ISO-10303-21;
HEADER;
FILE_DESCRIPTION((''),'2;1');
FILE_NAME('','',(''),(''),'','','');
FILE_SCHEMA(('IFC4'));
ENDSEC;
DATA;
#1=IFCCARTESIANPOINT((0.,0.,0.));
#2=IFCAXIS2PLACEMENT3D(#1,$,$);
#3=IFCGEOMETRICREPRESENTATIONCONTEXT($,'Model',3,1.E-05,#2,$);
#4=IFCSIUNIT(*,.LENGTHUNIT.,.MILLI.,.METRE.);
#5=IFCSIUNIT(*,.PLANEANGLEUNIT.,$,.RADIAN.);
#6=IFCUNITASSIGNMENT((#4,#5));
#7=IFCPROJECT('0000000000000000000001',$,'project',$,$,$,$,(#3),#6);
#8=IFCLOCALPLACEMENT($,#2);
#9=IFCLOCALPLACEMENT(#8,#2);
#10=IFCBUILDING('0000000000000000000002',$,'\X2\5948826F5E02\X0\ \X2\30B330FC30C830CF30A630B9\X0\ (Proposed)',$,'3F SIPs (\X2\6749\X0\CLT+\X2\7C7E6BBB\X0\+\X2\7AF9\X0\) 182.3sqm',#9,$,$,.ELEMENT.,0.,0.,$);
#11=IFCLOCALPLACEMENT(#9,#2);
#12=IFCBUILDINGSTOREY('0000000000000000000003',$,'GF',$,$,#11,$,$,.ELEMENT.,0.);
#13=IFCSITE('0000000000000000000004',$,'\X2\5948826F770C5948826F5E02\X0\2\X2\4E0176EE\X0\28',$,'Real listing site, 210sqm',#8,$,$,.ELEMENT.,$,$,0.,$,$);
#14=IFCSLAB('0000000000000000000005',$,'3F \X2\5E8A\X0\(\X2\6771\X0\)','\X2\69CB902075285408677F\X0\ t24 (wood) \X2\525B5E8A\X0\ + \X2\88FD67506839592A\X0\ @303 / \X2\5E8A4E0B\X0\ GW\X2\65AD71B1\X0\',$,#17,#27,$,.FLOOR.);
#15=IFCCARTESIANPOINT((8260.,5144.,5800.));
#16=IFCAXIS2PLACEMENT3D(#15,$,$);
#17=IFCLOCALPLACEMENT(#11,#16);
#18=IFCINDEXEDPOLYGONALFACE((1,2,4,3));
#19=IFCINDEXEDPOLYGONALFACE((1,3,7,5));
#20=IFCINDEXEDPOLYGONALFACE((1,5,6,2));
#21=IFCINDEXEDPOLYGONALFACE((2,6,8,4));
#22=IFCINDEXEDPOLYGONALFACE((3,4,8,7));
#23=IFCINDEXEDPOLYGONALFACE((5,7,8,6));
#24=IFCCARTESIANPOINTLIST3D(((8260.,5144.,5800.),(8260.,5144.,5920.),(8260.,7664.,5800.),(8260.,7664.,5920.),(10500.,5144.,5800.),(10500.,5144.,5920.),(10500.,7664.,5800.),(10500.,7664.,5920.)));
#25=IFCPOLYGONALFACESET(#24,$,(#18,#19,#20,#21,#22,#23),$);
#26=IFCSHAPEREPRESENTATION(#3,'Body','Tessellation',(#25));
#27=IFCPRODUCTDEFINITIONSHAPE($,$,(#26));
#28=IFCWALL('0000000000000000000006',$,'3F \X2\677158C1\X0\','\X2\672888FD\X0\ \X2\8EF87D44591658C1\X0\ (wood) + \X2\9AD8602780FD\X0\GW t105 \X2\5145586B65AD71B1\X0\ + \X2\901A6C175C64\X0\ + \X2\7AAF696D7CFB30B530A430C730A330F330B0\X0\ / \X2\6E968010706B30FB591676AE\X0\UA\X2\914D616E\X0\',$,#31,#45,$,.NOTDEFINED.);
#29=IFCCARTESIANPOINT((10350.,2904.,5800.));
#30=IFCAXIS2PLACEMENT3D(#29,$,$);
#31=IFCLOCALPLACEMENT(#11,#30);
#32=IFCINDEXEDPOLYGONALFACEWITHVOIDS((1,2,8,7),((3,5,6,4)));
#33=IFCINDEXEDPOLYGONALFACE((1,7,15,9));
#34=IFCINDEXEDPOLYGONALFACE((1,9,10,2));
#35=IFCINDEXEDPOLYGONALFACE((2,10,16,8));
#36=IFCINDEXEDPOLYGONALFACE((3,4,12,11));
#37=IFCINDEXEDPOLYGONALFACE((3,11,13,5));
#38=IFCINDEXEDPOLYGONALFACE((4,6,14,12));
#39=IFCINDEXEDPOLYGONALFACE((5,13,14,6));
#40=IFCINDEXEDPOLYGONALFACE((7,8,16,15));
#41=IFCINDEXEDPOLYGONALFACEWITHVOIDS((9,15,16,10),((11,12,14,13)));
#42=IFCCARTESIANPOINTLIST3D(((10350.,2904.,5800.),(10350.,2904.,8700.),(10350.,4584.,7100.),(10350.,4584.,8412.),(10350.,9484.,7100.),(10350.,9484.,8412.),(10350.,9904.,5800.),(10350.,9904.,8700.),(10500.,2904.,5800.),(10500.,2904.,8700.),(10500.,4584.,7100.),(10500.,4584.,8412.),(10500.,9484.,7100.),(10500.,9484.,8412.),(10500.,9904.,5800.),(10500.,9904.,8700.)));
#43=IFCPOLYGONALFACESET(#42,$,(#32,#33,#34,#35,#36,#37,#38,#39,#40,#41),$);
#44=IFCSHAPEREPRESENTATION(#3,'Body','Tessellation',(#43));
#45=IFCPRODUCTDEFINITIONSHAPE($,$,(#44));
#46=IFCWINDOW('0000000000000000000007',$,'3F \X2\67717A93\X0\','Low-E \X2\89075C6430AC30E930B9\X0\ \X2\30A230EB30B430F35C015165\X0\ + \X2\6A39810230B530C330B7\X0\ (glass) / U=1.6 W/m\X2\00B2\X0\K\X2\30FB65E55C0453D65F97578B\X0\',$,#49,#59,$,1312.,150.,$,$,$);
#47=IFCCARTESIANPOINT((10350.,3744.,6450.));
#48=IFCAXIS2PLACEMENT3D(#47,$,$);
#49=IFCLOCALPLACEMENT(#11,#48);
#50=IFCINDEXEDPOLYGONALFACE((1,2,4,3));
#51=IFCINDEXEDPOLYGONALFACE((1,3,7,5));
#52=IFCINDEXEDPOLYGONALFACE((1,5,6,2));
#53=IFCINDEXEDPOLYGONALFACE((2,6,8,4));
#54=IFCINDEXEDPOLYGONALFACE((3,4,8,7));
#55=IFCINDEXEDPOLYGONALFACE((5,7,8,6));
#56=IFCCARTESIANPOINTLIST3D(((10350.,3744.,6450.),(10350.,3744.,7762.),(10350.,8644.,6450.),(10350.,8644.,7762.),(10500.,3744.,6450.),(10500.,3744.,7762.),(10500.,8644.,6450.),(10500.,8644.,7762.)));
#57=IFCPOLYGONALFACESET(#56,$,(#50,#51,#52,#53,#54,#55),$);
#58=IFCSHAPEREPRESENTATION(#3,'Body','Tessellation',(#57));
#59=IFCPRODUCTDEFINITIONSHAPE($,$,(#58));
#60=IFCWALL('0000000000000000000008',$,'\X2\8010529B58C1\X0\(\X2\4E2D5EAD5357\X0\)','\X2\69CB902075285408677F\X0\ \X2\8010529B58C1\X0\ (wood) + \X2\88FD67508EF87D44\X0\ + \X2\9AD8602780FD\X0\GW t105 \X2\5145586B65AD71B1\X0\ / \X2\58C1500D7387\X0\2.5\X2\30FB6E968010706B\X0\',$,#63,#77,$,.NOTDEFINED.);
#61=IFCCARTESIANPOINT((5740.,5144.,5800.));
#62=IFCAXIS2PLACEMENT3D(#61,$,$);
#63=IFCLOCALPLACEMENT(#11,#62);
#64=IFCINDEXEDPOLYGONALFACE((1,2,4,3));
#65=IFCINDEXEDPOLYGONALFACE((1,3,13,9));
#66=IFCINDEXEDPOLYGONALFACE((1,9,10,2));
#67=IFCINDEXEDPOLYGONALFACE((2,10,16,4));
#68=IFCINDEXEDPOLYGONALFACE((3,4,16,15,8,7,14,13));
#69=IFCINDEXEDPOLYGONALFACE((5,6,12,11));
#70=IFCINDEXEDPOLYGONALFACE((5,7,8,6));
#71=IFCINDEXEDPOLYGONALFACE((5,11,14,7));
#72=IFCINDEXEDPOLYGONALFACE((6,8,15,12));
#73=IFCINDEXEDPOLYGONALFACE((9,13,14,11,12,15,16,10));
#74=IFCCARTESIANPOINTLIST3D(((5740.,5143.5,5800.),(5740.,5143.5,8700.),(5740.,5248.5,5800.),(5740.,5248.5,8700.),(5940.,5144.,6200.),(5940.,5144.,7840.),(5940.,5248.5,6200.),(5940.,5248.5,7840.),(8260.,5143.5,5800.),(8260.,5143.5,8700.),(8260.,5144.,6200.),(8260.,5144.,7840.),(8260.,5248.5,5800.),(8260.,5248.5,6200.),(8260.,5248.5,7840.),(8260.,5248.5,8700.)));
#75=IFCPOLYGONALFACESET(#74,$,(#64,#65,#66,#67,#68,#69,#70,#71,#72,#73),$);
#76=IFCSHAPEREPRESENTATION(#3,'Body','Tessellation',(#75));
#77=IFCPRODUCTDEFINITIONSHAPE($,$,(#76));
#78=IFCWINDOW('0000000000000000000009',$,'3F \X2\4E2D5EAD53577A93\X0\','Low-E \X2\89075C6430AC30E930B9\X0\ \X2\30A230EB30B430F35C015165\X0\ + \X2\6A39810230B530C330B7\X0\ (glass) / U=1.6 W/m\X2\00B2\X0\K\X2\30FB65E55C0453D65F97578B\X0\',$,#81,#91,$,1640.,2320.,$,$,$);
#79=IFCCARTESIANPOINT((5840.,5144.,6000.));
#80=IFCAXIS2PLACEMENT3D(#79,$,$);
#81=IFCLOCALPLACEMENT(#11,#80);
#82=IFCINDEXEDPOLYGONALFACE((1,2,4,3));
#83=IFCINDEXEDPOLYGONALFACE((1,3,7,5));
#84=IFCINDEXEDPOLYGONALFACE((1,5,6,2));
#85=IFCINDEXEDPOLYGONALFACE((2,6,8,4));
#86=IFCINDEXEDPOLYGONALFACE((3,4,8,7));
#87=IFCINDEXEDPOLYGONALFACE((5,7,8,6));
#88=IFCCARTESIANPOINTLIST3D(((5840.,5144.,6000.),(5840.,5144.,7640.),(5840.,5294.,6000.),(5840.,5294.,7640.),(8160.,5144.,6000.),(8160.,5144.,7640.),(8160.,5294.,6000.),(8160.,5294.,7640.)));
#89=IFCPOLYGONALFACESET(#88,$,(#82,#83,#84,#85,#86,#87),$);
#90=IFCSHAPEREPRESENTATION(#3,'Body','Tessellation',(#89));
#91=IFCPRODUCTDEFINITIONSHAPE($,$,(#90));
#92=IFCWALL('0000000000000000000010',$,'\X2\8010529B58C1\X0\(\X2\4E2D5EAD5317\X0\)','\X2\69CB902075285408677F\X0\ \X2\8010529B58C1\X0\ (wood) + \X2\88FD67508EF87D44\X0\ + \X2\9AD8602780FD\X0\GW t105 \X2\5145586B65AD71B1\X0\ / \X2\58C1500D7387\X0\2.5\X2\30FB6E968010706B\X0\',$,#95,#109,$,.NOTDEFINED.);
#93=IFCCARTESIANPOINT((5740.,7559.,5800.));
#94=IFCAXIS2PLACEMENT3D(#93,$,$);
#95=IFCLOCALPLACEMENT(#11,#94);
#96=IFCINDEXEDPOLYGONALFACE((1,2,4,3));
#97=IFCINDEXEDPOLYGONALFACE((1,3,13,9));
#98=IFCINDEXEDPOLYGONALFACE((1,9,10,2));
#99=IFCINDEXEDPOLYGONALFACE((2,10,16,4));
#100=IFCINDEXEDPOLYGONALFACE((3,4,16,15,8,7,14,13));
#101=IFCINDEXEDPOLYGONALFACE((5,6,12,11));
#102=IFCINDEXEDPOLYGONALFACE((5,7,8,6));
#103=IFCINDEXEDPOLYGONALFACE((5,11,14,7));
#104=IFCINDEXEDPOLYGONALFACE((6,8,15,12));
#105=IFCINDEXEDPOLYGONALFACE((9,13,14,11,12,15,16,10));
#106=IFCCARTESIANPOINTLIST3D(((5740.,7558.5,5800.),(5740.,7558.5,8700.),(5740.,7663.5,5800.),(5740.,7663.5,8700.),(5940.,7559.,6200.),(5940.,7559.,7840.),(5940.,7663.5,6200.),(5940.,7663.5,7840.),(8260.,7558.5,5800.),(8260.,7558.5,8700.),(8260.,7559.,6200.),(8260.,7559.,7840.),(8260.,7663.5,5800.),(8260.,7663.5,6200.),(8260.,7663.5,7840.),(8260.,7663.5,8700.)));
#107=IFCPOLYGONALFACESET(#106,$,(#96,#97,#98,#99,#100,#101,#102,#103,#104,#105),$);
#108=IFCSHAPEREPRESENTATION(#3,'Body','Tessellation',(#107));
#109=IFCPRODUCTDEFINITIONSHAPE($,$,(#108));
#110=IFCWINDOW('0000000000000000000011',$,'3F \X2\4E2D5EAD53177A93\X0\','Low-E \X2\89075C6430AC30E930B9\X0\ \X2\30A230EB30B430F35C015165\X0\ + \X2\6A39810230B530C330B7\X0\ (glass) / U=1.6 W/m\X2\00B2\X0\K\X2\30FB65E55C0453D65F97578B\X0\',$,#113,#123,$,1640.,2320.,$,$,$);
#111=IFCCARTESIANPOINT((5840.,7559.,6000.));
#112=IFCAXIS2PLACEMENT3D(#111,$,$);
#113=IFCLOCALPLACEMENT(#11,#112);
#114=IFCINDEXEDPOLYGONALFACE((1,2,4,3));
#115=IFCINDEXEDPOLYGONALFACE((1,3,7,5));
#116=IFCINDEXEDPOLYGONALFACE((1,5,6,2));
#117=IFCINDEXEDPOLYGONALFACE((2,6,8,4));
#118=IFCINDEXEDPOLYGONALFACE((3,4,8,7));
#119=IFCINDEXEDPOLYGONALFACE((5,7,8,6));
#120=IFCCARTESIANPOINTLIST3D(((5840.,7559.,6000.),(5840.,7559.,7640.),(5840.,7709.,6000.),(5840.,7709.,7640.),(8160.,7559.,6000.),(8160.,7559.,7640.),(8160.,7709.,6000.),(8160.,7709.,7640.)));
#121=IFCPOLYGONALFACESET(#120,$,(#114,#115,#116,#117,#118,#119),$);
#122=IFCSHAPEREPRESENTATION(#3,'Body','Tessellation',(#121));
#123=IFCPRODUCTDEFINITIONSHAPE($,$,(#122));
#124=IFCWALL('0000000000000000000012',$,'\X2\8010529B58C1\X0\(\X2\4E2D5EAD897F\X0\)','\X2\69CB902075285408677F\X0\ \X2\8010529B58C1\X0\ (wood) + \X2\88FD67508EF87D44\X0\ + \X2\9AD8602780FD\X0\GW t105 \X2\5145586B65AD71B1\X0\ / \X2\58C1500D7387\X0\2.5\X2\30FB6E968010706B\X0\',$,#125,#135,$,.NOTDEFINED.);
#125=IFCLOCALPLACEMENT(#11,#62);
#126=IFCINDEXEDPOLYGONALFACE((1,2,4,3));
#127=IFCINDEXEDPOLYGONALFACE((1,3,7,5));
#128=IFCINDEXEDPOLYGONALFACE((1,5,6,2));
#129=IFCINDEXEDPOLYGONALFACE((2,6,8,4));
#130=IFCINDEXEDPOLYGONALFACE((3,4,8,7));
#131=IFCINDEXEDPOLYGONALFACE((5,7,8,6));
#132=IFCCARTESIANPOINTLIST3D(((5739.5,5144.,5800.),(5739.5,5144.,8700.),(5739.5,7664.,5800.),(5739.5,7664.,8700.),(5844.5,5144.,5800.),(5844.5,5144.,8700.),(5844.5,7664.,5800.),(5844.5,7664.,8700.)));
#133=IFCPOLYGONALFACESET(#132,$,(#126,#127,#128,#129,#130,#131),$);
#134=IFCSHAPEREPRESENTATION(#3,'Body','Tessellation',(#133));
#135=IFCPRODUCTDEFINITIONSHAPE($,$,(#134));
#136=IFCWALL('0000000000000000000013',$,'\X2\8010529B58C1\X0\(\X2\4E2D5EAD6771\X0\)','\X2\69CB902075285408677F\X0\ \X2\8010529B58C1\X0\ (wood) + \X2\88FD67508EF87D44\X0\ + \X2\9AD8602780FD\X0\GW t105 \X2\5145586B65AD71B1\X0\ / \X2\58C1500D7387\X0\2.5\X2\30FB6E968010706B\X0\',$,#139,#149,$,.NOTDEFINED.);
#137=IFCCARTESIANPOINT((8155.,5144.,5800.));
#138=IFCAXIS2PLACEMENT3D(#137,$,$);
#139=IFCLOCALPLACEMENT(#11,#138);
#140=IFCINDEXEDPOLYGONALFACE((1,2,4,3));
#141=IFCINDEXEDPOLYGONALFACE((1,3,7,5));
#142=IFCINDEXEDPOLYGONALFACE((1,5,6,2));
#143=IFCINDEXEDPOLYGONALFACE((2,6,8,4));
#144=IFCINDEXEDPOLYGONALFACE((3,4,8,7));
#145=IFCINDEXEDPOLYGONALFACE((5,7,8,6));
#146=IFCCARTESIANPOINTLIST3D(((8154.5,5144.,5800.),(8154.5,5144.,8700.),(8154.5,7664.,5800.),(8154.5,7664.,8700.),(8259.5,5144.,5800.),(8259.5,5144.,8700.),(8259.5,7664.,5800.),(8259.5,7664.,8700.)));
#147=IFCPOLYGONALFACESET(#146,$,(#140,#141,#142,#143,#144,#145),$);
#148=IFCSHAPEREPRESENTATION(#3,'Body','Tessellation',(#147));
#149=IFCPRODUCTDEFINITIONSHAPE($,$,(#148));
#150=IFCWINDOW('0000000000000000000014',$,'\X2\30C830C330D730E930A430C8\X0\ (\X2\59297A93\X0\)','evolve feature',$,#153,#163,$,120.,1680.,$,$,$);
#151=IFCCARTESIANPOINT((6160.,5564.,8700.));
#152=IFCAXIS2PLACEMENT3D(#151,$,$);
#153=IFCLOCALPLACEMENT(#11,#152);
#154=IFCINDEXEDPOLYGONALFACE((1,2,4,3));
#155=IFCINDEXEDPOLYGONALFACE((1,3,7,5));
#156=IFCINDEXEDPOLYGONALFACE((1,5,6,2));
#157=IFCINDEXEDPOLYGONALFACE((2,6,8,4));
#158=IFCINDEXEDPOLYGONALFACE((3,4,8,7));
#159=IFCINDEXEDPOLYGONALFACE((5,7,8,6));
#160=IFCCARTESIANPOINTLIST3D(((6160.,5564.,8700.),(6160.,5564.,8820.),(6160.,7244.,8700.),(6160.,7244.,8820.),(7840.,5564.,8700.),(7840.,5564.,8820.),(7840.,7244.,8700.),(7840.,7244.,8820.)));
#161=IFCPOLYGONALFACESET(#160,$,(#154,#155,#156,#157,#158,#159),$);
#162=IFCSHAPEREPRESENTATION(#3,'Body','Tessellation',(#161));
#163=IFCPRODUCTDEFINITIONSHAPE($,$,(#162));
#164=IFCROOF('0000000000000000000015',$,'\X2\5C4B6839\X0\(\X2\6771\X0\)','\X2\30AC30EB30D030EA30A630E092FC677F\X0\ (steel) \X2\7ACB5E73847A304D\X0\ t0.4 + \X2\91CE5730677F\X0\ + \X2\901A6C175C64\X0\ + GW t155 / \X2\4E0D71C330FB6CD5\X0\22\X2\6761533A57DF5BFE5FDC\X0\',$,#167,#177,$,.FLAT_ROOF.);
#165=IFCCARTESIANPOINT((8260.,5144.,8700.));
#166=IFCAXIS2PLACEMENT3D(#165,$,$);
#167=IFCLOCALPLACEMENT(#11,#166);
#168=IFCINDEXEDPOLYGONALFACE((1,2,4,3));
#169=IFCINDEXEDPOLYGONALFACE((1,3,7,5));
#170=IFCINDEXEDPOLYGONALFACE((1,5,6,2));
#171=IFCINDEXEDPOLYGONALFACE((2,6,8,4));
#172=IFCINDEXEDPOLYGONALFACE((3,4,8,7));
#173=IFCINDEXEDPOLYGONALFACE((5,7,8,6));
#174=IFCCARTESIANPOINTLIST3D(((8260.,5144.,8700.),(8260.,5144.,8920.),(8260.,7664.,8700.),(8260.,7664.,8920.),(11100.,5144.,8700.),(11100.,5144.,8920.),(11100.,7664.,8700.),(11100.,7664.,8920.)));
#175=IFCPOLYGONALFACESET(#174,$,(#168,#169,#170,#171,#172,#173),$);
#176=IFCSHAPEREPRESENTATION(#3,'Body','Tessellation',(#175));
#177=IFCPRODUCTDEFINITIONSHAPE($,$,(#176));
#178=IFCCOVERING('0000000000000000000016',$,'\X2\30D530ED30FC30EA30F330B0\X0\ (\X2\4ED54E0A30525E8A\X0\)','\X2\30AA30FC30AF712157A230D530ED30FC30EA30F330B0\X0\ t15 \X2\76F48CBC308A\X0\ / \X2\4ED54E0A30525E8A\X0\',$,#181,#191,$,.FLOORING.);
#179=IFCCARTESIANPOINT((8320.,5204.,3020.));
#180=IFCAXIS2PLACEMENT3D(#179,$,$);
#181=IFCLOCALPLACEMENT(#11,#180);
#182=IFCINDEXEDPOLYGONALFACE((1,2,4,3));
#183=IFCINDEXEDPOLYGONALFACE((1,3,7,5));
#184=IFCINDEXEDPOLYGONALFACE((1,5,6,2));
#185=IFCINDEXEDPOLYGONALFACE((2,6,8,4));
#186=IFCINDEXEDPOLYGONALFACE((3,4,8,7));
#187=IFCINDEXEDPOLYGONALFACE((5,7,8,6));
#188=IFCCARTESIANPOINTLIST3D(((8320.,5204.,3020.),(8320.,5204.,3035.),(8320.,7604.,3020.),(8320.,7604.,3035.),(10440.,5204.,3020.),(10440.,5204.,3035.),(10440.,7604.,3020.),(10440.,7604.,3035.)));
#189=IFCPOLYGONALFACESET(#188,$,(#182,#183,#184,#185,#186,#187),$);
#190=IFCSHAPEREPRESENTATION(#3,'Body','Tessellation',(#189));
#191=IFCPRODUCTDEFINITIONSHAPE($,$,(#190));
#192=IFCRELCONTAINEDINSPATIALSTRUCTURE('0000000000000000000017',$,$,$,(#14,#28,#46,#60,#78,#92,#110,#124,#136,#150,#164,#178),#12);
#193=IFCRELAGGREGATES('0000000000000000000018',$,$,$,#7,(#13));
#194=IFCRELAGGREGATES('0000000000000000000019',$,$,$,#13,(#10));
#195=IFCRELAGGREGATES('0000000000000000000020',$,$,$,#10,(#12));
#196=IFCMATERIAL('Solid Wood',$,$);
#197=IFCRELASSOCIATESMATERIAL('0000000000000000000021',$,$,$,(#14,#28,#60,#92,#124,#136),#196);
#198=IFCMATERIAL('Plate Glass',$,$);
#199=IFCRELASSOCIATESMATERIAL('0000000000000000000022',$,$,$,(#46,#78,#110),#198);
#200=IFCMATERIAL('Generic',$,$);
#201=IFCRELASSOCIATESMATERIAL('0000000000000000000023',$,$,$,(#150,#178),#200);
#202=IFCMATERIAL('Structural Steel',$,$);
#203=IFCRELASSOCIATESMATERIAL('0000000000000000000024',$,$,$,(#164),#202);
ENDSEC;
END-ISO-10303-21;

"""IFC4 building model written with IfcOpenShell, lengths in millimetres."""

from ifc_helpers import new_model, si_unit, frame, frame_2d, origin, place, context, project, spatial, rectangle, extrude, material, element, fill, save


model = new_model("IFC4")

# Units and contexts
model_context = context("Model", 3, precision=1e-05, world=origin())
ifc_project = project(units=[si_unit("LENGTHUNIT", "METRE", prefix="MILLI"), si_unit("PLANEANGLEUNIT", "RADIAN")], contexts=[model_context])

# Site, building, storey
site_placement = place(None, origin())
site = spatial("IfcSite", under=ifc_project, at=site_placement, Name="奈良県奈良市2丁目28", ObjectType="Real listing site, 210sqm", CompositionType="ELEMENT", RefElevation=0.0)
building_placement = place(site_placement, origin())
building = spatial("IfcBuilding", under=site, at=building_placement, Name="奈良市 コートハウス (Proposed)", ObjectType="3F SIPs (杉CLT+籾殻+竹) 182.3sqm", CompositionType="ELEMENT", ElevationOfRefHeight=0.0, ElevationOfTerrain=0.0)
storey_placement = place(building_placement, origin())
storey = spatial("IfcBuildingStorey", under=building, at=storey_placement, Name="GF", CompositionType="ELEMENT", Elevation=0.0)

# Slab
ifc_material_1 = material(Name="Solid Wood")
slab_placement = place(storey_placement, frame((8260.0, 5144.0, 5800.0)))
element("IfcSlab", 1, at=slab_placement, inside=storey, material=ifc_material_1, Name="3F 床(東)", Description="構造用合板 t24 (wood) 剛床 + 製材根太 @303 / 床下 GW断熱", PredefinedType="FLOOR", context=model_context, shape_type="SweptSolid", body=[
    extrude(rectangle(XDim=2240.0, YDim=2520.0, at=frame_2d((1120.0, 1260.0))), frame((8260.0, 5144.0, 5800.0)), (0.0, 0.0, 1.0), 120.0),
])

# Walls, openings, windows
wall_1_placement = place(storey_placement, frame((10350.0, 2904.0, 5800.0)))
wall_1 = element("IfcWall", 2, at=wall_1_placement, inside=storey, material=ifc_material_1, Name="3F 東壁", Description="木製 軸組外壁 (wood) + 高性能GW t105 充填断熱 + 通気層 + 窯業系サイディング / 準耐火・外皮UA配慮", PredefinedType="NOTDEFINED", context=model_context, shape_type="SweptSolid", body=[
    extrude(rectangle(XDim=150.0, YDim=7000.0, at=frame_2d((75.0, 3500.0))), frame((10350.0, 2904.0, 5800.0)), (0.0, 0.0, 1.0), 2900.0),
])
opening_1_placement = place(storey_placement, frame((10350.0, 3744.0, 6450.0)))
opening_1 = element("IfcOpeningElement", 3, at=opening_1_placement, cuts=wall_1, PredefinedType="NOTDEFINED", context=model_context, shape_type="SweptSolid", body=[
    extrude(rectangle(XDim=150.0, YDim=4900.0, at=frame_2d((75.0, 2450.0))), frame((10350.0, 3744.0, 6450.0)), (0.0, 0.0, 1.0), 1312.0),
])
ifc_material_2 = material(Name="Plate Glass")
window_1_placement = place(storey_placement, frame((10350.0, 3744.0, 6450.0)))
window_1 = element("IfcWindow", 4, at=window_1_placement, inside=storey, material=ifc_material_2, Name="3F 東窓", Description="Low-E 複層ガラス アルゴン封入 + 樹脂サッシ (glass) / U=1.6 W/m²K・日射取得型", OverallHeight=1312.0, OverallWidth=150.0, context=model_context, shape_type="SweptSolid", body=[
    extrude(rectangle(XDim=150.0, YDim=4900.0, at=frame_2d((75.0, 2450.0))), frame((10350.0, 3744.0, 6450.0)), (0.0, 0.0, 1.0), 1312.0),
])
fill(opening_1, window_1)
wall_2_placement = place(storey_placement, frame((5740.0, 5144.0, 5800.0)))
wall_2 = element("IfcWall", 5, at=wall_2_placement, inside=storey, material=ifc_material_1, Name="耐力壁(中庭南)", Description="構造用合板 耐力壁 (wood) + 製材軸組 + 高性能GW t105 充填断熱 / 壁倍率2.5・準耐火", PredefinedType="NOTDEFINED", context=model_context, shape_type="SweptSolid", body=[
    extrude(rectangle(XDim=2520.0, YDim=105.0, at=frame_2d((1260.0, 52.0))), frame((5740.0, 5144.0, 5800.0)), (0.0, 0.0, 1.0), 2900.0),
])
opening_2_placement = place(storey_placement, frame((5840.0, 5144.0, 6000.0)))
opening_2 = element("IfcOpeningElement", 6, at=opening_2_placement, cuts=wall_2, PredefinedType="NOTDEFINED", context=model_context, shape_type="SweptSolid", body=[
    extrude(rectangle(XDim=2320.0, YDim=150.0, at=frame_2d((1160.0, 75.0))), frame((5840.0, 5144.0, 6000.0)), (0.0, 0.0, 1.0), 1640.0),
])
window_2_placement = place(storey_placement, frame((5840.0, 5144.0, 6000.0)))
window_2 = element("IfcWindow", 7, at=window_2_placement, inside=storey, material=ifc_material_2, Name="3F 中庭南窓", Description="Low-E 複層ガラス アルゴン封入 + 樹脂サッシ (glass) / U=1.6 W/m²K・日射取得型", OverallHeight=1640.0, OverallWidth=2320.0, context=model_context, shape_type="SweptSolid", body=[
    extrude(rectangle(XDim=2320.0, YDim=150.0, at=frame_2d((1160.0, 75.0))), frame((5840.0, 5144.0, 6000.0)), (0.0, 0.0, 1.0), 1640.0),
])
fill(opening_2, window_2)
wall_3_placement = place(storey_placement, frame((5740.0, 7559.0, 5800.0)))
wall_3 = element("IfcWall", 8, at=wall_3_placement, inside=storey, material=ifc_material_1, Name="耐力壁(中庭北)", Description="構造用合板 耐力壁 (wood) + 製材軸組 + 高性能GW t105 充填断熱 / 壁倍率2.5・準耐火", PredefinedType="NOTDEFINED", context=model_context, shape_type="SweptSolid", body=[
    extrude(rectangle(XDim=2520.0, YDim=105.0, at=frame_2d((1260.0, 52.0))), frame((5740.0, 7559.0, 5800.0)), (0.0, 0.0, 1.0), 2900.0),
])
opening_3_placement = place(storey_placement, frame((5840.0, 7559.0, 6000.0)))
opening_3 = element("IfcOpeningElement", 9, at=opening_3_placement, cuts=wall_3, PredefinedType="NOTDEFINED", context=model_context, shape_type="SweptSolid", body=[
    extrude(rectangle(XDim=2320.0, YDim=150.0, at=frame_2d((1160.0, 75.0))), frame((5840.0, 7559.0, 6000.0)), (0.0, 0.0, 1.0), 1640.0),
])
window_3_placement = place(storey_placement, frame((5840.0, 7559.0, 6000.0)))
window_3 = element("IfcWindow", 10, at=window_3_placement, inside=storey, material=ifc_material_2, Name="3F 中庭北窓", Description="Low-E 複層ガラス アルゴン封入 + 樹脂サッシ (glass) / U=1.6 W/m²K・日射取得型", OverallHeight=1640.0, OverallWidth=2320.0, context=model_context, shape_type="SweptSolid", body=[
    extrude(rectangle(XDim=2320.0, YDim=150.0, at=frame_2d((1160.0, 75.0))), frame((5840.0, 7559.0, 6000.0)), (0.0, 0.0, 1.0), 1640.0),
])
fill(opening_3, window_3)

# Walls
wall_4_placement = place(storey_placement, frame((5740.0, 5144.0, 5800.0)))
element("IfcWall", 11, at=wall_4_placement, inside=storey, material=ifc_material_1, Name="耐力壁(中庭西)", Description="構造用合板 耐力壁 (wood) + 製材軸組 + 高性能GW t105 充填断熱 / 壁倍率2.5・準耐火", PredefinedType="NOTDEFINED", context=model_context, shape_type="SweptSolid", body=[
    extrude(rectangle(XDim=105.0, YDim=2520.0, at=frame_2d((52.0, 1260.0))), frame((5740.0, 5144.0, 5800.0)), (0.0, 0.0, 1.0), 2900.0),
])
wall_5_placement = place(storey_placement, frame((8155.0, 5144.0, 5800.0)))
element("IfcWall", 12, at=wall_5_placement, inside=storey, material=ifc_material_1, Name="耐力壁(中庭東)", Description="構造用合板 耐力壁 (wood) + 製材軸組 + 高性能GW t105 充填断熱 / 壁倍率2.5・準耐火", PredefinedType="NOTDEFINED", context=model_context, shape_type="SweptSolid", body=[
    extrude(rectangle(XDim=105.0, YDim=2520.0, at=frame_2d((52.0, 1260.0))), frame((8155.0, 5144.0, 5800.0)), (0.0, 0.0, 1.0), 2900.0),
])

# Window
ifc_material_3 = material(Name="Generic")
window_4_placement = place(storey_placement, frame((6160.0, 5564.0, 8700.0)))
element("IfcWindow", 13, at=window_4_placement, inside=storey, material=ifc_material_3, Name="トップライト (天窓)", Description="evolve feature", OverallHeight=120.0, OverallWidth=1680.0, context=model_context, shape_type="SweptSolid", body=[
    extrude(rectangle(XDim=1680.0, YDim=1680.0, at=frame_2d((840.0, 840.0))), frame((6160.0, 5564.0, 8700.0)), (0.0, 0.0, 1.0), 120.0),
])

# Roof
ifc_material_4 = material(Name="Structural Steel")
for number, where, name in (
    (14, (8260.0, 5144.0, 8700.0), "屋根(東)"),
):
    element("IfcRoof", number, at=place(storey_placement, frame(where)), inside=storey, material=ifc_material_4, Name=name, Description="ガルバリウム鋼板 (steel) 立平葺き t0.4 + 野地板 + 通気層 + GW t155 / 不燃・法22条区域対応", PredefinedType="FLAT_ROOF", context=model_context, shape_type="SweptSolid", body=[
        extrude(rectangle(XDim=2840.0, YDim=2520.0, at=frame_2d((1420.0, 1260.0))), frame((8260.0, 5144.0, 8700.0)), (0.0, 0.0, 1.0), 220.0),
    ])

# Covering
covering_1_placement = place(storey_placement, frame((8320.0, 5204.0, 3020.0)))
element("IfcCovering", 15, at=covering_1_placement, inside=storey, material=ifc_material_3, Name="フローリング (仕上げ床)", Description="オーク無垢フローリング t15 直貼り / 仕上げ床", PredefinedType="FLOORING", context=model_context, shape_type="SweptSolid", body=[
    extrude(rectangle(XDim=2120.0, YDim=2400.0, at=frame_2d((1060.0, 1200.0))), frame((8320.0, 5204.0, 3020.0)), (0.0, 0.0, 1.0), 15.0),
])

save(model, "model.ifc")
